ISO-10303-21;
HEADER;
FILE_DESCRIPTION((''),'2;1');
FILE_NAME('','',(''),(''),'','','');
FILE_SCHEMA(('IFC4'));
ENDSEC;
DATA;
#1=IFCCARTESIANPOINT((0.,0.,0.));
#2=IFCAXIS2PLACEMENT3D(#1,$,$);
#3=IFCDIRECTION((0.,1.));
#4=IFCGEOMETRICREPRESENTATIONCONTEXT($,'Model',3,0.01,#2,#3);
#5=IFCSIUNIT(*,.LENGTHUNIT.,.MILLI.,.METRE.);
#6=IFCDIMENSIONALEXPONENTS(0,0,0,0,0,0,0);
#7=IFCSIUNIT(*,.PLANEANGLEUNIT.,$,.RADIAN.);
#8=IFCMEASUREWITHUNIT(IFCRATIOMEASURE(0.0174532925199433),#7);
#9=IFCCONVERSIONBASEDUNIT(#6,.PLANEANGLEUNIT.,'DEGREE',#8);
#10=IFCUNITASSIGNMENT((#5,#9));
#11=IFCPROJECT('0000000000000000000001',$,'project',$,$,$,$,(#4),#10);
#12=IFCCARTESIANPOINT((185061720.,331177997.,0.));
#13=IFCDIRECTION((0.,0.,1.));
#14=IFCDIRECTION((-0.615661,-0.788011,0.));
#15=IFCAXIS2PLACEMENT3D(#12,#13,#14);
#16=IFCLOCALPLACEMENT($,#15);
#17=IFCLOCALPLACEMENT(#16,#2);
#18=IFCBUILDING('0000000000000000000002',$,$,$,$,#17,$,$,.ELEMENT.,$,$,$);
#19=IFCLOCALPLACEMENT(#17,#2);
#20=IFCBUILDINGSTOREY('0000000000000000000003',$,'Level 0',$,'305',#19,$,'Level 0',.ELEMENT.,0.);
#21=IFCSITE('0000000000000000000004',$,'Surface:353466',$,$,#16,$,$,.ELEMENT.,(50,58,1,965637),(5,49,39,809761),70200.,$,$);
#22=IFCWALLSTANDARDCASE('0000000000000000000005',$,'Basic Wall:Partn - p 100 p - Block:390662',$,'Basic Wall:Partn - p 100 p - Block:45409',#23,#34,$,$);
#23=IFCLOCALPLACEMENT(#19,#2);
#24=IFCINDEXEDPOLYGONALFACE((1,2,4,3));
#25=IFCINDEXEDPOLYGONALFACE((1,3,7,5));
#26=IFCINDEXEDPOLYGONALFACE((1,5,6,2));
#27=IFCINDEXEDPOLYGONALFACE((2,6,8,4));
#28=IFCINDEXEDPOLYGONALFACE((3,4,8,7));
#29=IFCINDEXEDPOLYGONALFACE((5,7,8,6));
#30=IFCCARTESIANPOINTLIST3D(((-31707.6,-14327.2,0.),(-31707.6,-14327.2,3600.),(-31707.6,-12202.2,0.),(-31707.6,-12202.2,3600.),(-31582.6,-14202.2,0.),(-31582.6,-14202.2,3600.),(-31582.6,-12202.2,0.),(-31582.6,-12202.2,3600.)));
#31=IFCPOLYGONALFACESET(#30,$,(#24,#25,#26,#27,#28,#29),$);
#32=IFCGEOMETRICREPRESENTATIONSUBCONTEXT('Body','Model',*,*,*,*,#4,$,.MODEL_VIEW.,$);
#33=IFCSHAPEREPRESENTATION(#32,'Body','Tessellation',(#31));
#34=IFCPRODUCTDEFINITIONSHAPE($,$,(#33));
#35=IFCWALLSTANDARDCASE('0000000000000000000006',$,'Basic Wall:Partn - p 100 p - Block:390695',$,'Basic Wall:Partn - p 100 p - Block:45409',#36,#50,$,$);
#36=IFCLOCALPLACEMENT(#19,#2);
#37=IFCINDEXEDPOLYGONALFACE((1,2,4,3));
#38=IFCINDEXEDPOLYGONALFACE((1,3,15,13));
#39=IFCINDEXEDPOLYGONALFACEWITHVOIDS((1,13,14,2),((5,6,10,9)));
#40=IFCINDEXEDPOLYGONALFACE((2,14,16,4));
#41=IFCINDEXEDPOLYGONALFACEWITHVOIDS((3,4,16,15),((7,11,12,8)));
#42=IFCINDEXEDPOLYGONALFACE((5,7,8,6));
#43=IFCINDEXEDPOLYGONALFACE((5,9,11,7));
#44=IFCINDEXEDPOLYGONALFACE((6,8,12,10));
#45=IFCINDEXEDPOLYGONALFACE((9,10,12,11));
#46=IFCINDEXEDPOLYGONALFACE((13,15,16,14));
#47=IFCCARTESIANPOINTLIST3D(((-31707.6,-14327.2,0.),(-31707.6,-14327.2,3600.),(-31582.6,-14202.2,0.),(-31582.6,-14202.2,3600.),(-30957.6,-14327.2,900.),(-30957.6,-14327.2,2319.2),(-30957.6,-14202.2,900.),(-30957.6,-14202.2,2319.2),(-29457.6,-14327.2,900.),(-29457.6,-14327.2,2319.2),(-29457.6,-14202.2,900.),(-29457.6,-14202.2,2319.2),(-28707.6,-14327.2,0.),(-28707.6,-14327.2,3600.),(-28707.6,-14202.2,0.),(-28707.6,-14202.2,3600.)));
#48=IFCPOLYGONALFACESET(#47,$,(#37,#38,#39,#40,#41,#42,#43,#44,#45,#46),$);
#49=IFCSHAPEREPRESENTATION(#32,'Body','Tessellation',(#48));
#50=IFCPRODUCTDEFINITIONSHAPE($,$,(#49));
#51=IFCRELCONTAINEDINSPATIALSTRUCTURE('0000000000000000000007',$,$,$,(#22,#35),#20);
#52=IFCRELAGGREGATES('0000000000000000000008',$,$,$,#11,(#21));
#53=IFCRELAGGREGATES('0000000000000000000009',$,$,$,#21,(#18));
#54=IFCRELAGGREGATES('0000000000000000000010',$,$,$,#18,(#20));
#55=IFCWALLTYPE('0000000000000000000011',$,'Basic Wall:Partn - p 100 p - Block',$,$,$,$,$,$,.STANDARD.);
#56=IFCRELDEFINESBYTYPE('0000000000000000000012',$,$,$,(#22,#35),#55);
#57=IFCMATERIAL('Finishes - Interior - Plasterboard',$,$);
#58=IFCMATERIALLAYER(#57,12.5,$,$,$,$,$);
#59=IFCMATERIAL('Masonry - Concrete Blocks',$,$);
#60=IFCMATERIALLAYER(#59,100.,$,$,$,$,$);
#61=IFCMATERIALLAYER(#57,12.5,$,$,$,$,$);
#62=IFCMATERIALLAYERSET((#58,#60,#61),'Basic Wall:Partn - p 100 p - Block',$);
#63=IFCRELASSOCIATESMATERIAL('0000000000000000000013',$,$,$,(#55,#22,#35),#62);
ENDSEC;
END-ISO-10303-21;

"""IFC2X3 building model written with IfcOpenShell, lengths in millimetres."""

from ifc_helpers import new_model, entity, si_unit, converted_unit, direction, frame, frame_2d, origin, place, context, subcontext, project, spatial, polyline, rectangle, outline, extrude, clip, bounded_halfspace, material, layer, layer_set, layer_usage, type_object, element, save


model = new_model("IFC2X3")

# Units and contexts
model_context = context("Model", 3, precision=0.01, world=origin(), true_north=direction((0.0, 1.0)))
body_context = subcontext(model_context, "Body", "Model", "MODEL_VIEW")
ifc_project = project(units=[si_unit("LENGTHUNIT", "METRE", prefix="MILLI"), converted_unit("PLANEANGLEUNIT", "DEGREE", entity("IfcRatioMeasure", 0.0174532925199433), si_unit("PLANEANGLEUNIT", "RADIAN"), dimensions=[0, 0, 0, 0, 0, 0, 0])], contexts=[model_context])

# Site, building, storey
site_placement = place(None, frame((185061720.0, 331177997.0, 0.0), z_axis=(0.0, 0.0, 1.0), x_axis=(-0.615661, -0.788011, 0.0)))
site = spatial("IfcSite", under=ifc_project, at=site_placement, Name="Surface:353466", CompositionType="ELEMENT", RefLatitude=(50, 58, 1, 965637), RefLongitude=(5, 49, 39, 809761), RefElevation=70200.0)
building_placement = place(site_placement, origin())
building = spatial("IfcBuilding", under=site, at=building_placement, CompositionType="ELEMENT")
storey_placement = place(building_placement, origin())
storey = spatial("IfcBuildingStorey", under=building, at=storey_placement, Name="Level 0", ObjectType="305", LongName="Level 0", CompositionType="ELEMENT", Elevation=0.0)

# Shared definitions
ifc_material_1 = material(Name="Masonry - Concrete Blocks")
ifc_material_2 = material(Name="Finishes - Interior - Plasterboard")

# Wall
ifc_layer_1 = layer(ifc_material_2, 12.5)
ifc_layer_2 = layer(ifc_material_1, 100.0)
ifc_layer_3 = layer(ifc_material_2, 12.5)
ifc_layer_set_1 = layer_set([ifc_layer_1, ifc_layer_2, ifc_layer_3], Name="Basic Wall:Partn - p 100 p - Block")
ifc_layer_usage_1 = layer_usage(ifc_layer_set_1, "AXIS2", "NEGATIVE", 62.5)
wall_type_1 = type_object("IfcWallType", Name="Basic Wall:Partn - p 100 p - Block", PredefinedType="STANDARD", material=ifc_layer_set_1)
wall_1_placement = place(storey_placement, frame((-31645.1, -12202.2, 0.0), z_axis=(0.0, 0.0, 1.0), x_axis=(0.0, -1.0, 0.0)))
element("IfcWallStandardCase", 1, at=wall_1_placement, inside=storey, type_object=wall_type_1, material=ifc_layer_usage_1, Name="Basic Wall:Partn - p 100 p - Block:390662", ObjectType="Basic Wall:Partn - p 100 p - Block:45409", context=body_context, shape_type="Clipping", body=[
    clip(extrude(outline(polyline([(2125.0, -62.5), (2000.0, 62.5), (0.0, 62.5), (0.0, -62.5), (2125.0, -62.5)])), origin(), (0.0, 0.0, 1.0), 3600.0), bounded_halfspace(frame((0.0, -62.5, 3600.0), z_axis=(0.0, 0.0, -1.0), x_axis=(0.0, 1.0, 0.0)), True, frame((0.0, -62.5, 3600.0)), polyline([(0.0, 0.0), (2125.0, 0.0), (2000.0, 125.0), (0.0, 125.0), (0.0, 0.0)]))),
])

# Wall, opening
ifc_layer_usage_2 = layer_usage(ifc_layer_set_1, "AXIS2", "NEGATIVE", 62.5)
wall_2_placement = place(storey_placement, frame((-31707.6, -14264.7, 0.0)))
wall_2 = element("IfcWallStandardCase", 2, at=wall_2_placement, inside=storey, type_object=wall_type_1, material=ifc_layer_usage_2, Name="Basic Wall:Partn - p 100 p - Block:390695", ObjectType="Basic Wall:Partn - p 100 p - Block:45409", context=body_context, shape_type="Clipping", body=[
    clip(extrude(outline(polyline([(3000.0, -62.5), (3000.0, 62.5), (125.0, 62.5), (0.0, -62.5), (3000.0, -62.5)])), origin(), (0.0, 0.0, 1.0), 3600.0), bounded_halfspace(frame((0.0, -62.5, 3600.0), z_axis=(0.0, 0.0, -1.0), x_axis=(1.0, 0.0, 0.0)), True, frame((0.0, -62.5, 3600.0)), polyline([(0.0, 0.0), (3000.0, 0.0), (3000.0, 125.0), (125.0, 125.0), (0.0, 0.0)]))),
])
opening_1_placement = place(wall_2_placement, origin())
element("IfcOpeningElement", 3, at=opening_1_placement, cuts=wall_2, ObjectType="Opening", context=body_context, shape_type="SweptSolid", body=[
    extrude(rectangle(XDim=1419.2, YDim=1500.0, at=frame_2d((0.0, 0.0), x_axis=(1.0, 0.0))), frame((1500.0, -62.5, 1609.6), z_axis=(0.0, 1.0, 0.0), x_axis=(0.0, 0.0, -1.0)), (0.0, 0.0, 1.0), 125.0),
])

save(model, "model.ifc")
